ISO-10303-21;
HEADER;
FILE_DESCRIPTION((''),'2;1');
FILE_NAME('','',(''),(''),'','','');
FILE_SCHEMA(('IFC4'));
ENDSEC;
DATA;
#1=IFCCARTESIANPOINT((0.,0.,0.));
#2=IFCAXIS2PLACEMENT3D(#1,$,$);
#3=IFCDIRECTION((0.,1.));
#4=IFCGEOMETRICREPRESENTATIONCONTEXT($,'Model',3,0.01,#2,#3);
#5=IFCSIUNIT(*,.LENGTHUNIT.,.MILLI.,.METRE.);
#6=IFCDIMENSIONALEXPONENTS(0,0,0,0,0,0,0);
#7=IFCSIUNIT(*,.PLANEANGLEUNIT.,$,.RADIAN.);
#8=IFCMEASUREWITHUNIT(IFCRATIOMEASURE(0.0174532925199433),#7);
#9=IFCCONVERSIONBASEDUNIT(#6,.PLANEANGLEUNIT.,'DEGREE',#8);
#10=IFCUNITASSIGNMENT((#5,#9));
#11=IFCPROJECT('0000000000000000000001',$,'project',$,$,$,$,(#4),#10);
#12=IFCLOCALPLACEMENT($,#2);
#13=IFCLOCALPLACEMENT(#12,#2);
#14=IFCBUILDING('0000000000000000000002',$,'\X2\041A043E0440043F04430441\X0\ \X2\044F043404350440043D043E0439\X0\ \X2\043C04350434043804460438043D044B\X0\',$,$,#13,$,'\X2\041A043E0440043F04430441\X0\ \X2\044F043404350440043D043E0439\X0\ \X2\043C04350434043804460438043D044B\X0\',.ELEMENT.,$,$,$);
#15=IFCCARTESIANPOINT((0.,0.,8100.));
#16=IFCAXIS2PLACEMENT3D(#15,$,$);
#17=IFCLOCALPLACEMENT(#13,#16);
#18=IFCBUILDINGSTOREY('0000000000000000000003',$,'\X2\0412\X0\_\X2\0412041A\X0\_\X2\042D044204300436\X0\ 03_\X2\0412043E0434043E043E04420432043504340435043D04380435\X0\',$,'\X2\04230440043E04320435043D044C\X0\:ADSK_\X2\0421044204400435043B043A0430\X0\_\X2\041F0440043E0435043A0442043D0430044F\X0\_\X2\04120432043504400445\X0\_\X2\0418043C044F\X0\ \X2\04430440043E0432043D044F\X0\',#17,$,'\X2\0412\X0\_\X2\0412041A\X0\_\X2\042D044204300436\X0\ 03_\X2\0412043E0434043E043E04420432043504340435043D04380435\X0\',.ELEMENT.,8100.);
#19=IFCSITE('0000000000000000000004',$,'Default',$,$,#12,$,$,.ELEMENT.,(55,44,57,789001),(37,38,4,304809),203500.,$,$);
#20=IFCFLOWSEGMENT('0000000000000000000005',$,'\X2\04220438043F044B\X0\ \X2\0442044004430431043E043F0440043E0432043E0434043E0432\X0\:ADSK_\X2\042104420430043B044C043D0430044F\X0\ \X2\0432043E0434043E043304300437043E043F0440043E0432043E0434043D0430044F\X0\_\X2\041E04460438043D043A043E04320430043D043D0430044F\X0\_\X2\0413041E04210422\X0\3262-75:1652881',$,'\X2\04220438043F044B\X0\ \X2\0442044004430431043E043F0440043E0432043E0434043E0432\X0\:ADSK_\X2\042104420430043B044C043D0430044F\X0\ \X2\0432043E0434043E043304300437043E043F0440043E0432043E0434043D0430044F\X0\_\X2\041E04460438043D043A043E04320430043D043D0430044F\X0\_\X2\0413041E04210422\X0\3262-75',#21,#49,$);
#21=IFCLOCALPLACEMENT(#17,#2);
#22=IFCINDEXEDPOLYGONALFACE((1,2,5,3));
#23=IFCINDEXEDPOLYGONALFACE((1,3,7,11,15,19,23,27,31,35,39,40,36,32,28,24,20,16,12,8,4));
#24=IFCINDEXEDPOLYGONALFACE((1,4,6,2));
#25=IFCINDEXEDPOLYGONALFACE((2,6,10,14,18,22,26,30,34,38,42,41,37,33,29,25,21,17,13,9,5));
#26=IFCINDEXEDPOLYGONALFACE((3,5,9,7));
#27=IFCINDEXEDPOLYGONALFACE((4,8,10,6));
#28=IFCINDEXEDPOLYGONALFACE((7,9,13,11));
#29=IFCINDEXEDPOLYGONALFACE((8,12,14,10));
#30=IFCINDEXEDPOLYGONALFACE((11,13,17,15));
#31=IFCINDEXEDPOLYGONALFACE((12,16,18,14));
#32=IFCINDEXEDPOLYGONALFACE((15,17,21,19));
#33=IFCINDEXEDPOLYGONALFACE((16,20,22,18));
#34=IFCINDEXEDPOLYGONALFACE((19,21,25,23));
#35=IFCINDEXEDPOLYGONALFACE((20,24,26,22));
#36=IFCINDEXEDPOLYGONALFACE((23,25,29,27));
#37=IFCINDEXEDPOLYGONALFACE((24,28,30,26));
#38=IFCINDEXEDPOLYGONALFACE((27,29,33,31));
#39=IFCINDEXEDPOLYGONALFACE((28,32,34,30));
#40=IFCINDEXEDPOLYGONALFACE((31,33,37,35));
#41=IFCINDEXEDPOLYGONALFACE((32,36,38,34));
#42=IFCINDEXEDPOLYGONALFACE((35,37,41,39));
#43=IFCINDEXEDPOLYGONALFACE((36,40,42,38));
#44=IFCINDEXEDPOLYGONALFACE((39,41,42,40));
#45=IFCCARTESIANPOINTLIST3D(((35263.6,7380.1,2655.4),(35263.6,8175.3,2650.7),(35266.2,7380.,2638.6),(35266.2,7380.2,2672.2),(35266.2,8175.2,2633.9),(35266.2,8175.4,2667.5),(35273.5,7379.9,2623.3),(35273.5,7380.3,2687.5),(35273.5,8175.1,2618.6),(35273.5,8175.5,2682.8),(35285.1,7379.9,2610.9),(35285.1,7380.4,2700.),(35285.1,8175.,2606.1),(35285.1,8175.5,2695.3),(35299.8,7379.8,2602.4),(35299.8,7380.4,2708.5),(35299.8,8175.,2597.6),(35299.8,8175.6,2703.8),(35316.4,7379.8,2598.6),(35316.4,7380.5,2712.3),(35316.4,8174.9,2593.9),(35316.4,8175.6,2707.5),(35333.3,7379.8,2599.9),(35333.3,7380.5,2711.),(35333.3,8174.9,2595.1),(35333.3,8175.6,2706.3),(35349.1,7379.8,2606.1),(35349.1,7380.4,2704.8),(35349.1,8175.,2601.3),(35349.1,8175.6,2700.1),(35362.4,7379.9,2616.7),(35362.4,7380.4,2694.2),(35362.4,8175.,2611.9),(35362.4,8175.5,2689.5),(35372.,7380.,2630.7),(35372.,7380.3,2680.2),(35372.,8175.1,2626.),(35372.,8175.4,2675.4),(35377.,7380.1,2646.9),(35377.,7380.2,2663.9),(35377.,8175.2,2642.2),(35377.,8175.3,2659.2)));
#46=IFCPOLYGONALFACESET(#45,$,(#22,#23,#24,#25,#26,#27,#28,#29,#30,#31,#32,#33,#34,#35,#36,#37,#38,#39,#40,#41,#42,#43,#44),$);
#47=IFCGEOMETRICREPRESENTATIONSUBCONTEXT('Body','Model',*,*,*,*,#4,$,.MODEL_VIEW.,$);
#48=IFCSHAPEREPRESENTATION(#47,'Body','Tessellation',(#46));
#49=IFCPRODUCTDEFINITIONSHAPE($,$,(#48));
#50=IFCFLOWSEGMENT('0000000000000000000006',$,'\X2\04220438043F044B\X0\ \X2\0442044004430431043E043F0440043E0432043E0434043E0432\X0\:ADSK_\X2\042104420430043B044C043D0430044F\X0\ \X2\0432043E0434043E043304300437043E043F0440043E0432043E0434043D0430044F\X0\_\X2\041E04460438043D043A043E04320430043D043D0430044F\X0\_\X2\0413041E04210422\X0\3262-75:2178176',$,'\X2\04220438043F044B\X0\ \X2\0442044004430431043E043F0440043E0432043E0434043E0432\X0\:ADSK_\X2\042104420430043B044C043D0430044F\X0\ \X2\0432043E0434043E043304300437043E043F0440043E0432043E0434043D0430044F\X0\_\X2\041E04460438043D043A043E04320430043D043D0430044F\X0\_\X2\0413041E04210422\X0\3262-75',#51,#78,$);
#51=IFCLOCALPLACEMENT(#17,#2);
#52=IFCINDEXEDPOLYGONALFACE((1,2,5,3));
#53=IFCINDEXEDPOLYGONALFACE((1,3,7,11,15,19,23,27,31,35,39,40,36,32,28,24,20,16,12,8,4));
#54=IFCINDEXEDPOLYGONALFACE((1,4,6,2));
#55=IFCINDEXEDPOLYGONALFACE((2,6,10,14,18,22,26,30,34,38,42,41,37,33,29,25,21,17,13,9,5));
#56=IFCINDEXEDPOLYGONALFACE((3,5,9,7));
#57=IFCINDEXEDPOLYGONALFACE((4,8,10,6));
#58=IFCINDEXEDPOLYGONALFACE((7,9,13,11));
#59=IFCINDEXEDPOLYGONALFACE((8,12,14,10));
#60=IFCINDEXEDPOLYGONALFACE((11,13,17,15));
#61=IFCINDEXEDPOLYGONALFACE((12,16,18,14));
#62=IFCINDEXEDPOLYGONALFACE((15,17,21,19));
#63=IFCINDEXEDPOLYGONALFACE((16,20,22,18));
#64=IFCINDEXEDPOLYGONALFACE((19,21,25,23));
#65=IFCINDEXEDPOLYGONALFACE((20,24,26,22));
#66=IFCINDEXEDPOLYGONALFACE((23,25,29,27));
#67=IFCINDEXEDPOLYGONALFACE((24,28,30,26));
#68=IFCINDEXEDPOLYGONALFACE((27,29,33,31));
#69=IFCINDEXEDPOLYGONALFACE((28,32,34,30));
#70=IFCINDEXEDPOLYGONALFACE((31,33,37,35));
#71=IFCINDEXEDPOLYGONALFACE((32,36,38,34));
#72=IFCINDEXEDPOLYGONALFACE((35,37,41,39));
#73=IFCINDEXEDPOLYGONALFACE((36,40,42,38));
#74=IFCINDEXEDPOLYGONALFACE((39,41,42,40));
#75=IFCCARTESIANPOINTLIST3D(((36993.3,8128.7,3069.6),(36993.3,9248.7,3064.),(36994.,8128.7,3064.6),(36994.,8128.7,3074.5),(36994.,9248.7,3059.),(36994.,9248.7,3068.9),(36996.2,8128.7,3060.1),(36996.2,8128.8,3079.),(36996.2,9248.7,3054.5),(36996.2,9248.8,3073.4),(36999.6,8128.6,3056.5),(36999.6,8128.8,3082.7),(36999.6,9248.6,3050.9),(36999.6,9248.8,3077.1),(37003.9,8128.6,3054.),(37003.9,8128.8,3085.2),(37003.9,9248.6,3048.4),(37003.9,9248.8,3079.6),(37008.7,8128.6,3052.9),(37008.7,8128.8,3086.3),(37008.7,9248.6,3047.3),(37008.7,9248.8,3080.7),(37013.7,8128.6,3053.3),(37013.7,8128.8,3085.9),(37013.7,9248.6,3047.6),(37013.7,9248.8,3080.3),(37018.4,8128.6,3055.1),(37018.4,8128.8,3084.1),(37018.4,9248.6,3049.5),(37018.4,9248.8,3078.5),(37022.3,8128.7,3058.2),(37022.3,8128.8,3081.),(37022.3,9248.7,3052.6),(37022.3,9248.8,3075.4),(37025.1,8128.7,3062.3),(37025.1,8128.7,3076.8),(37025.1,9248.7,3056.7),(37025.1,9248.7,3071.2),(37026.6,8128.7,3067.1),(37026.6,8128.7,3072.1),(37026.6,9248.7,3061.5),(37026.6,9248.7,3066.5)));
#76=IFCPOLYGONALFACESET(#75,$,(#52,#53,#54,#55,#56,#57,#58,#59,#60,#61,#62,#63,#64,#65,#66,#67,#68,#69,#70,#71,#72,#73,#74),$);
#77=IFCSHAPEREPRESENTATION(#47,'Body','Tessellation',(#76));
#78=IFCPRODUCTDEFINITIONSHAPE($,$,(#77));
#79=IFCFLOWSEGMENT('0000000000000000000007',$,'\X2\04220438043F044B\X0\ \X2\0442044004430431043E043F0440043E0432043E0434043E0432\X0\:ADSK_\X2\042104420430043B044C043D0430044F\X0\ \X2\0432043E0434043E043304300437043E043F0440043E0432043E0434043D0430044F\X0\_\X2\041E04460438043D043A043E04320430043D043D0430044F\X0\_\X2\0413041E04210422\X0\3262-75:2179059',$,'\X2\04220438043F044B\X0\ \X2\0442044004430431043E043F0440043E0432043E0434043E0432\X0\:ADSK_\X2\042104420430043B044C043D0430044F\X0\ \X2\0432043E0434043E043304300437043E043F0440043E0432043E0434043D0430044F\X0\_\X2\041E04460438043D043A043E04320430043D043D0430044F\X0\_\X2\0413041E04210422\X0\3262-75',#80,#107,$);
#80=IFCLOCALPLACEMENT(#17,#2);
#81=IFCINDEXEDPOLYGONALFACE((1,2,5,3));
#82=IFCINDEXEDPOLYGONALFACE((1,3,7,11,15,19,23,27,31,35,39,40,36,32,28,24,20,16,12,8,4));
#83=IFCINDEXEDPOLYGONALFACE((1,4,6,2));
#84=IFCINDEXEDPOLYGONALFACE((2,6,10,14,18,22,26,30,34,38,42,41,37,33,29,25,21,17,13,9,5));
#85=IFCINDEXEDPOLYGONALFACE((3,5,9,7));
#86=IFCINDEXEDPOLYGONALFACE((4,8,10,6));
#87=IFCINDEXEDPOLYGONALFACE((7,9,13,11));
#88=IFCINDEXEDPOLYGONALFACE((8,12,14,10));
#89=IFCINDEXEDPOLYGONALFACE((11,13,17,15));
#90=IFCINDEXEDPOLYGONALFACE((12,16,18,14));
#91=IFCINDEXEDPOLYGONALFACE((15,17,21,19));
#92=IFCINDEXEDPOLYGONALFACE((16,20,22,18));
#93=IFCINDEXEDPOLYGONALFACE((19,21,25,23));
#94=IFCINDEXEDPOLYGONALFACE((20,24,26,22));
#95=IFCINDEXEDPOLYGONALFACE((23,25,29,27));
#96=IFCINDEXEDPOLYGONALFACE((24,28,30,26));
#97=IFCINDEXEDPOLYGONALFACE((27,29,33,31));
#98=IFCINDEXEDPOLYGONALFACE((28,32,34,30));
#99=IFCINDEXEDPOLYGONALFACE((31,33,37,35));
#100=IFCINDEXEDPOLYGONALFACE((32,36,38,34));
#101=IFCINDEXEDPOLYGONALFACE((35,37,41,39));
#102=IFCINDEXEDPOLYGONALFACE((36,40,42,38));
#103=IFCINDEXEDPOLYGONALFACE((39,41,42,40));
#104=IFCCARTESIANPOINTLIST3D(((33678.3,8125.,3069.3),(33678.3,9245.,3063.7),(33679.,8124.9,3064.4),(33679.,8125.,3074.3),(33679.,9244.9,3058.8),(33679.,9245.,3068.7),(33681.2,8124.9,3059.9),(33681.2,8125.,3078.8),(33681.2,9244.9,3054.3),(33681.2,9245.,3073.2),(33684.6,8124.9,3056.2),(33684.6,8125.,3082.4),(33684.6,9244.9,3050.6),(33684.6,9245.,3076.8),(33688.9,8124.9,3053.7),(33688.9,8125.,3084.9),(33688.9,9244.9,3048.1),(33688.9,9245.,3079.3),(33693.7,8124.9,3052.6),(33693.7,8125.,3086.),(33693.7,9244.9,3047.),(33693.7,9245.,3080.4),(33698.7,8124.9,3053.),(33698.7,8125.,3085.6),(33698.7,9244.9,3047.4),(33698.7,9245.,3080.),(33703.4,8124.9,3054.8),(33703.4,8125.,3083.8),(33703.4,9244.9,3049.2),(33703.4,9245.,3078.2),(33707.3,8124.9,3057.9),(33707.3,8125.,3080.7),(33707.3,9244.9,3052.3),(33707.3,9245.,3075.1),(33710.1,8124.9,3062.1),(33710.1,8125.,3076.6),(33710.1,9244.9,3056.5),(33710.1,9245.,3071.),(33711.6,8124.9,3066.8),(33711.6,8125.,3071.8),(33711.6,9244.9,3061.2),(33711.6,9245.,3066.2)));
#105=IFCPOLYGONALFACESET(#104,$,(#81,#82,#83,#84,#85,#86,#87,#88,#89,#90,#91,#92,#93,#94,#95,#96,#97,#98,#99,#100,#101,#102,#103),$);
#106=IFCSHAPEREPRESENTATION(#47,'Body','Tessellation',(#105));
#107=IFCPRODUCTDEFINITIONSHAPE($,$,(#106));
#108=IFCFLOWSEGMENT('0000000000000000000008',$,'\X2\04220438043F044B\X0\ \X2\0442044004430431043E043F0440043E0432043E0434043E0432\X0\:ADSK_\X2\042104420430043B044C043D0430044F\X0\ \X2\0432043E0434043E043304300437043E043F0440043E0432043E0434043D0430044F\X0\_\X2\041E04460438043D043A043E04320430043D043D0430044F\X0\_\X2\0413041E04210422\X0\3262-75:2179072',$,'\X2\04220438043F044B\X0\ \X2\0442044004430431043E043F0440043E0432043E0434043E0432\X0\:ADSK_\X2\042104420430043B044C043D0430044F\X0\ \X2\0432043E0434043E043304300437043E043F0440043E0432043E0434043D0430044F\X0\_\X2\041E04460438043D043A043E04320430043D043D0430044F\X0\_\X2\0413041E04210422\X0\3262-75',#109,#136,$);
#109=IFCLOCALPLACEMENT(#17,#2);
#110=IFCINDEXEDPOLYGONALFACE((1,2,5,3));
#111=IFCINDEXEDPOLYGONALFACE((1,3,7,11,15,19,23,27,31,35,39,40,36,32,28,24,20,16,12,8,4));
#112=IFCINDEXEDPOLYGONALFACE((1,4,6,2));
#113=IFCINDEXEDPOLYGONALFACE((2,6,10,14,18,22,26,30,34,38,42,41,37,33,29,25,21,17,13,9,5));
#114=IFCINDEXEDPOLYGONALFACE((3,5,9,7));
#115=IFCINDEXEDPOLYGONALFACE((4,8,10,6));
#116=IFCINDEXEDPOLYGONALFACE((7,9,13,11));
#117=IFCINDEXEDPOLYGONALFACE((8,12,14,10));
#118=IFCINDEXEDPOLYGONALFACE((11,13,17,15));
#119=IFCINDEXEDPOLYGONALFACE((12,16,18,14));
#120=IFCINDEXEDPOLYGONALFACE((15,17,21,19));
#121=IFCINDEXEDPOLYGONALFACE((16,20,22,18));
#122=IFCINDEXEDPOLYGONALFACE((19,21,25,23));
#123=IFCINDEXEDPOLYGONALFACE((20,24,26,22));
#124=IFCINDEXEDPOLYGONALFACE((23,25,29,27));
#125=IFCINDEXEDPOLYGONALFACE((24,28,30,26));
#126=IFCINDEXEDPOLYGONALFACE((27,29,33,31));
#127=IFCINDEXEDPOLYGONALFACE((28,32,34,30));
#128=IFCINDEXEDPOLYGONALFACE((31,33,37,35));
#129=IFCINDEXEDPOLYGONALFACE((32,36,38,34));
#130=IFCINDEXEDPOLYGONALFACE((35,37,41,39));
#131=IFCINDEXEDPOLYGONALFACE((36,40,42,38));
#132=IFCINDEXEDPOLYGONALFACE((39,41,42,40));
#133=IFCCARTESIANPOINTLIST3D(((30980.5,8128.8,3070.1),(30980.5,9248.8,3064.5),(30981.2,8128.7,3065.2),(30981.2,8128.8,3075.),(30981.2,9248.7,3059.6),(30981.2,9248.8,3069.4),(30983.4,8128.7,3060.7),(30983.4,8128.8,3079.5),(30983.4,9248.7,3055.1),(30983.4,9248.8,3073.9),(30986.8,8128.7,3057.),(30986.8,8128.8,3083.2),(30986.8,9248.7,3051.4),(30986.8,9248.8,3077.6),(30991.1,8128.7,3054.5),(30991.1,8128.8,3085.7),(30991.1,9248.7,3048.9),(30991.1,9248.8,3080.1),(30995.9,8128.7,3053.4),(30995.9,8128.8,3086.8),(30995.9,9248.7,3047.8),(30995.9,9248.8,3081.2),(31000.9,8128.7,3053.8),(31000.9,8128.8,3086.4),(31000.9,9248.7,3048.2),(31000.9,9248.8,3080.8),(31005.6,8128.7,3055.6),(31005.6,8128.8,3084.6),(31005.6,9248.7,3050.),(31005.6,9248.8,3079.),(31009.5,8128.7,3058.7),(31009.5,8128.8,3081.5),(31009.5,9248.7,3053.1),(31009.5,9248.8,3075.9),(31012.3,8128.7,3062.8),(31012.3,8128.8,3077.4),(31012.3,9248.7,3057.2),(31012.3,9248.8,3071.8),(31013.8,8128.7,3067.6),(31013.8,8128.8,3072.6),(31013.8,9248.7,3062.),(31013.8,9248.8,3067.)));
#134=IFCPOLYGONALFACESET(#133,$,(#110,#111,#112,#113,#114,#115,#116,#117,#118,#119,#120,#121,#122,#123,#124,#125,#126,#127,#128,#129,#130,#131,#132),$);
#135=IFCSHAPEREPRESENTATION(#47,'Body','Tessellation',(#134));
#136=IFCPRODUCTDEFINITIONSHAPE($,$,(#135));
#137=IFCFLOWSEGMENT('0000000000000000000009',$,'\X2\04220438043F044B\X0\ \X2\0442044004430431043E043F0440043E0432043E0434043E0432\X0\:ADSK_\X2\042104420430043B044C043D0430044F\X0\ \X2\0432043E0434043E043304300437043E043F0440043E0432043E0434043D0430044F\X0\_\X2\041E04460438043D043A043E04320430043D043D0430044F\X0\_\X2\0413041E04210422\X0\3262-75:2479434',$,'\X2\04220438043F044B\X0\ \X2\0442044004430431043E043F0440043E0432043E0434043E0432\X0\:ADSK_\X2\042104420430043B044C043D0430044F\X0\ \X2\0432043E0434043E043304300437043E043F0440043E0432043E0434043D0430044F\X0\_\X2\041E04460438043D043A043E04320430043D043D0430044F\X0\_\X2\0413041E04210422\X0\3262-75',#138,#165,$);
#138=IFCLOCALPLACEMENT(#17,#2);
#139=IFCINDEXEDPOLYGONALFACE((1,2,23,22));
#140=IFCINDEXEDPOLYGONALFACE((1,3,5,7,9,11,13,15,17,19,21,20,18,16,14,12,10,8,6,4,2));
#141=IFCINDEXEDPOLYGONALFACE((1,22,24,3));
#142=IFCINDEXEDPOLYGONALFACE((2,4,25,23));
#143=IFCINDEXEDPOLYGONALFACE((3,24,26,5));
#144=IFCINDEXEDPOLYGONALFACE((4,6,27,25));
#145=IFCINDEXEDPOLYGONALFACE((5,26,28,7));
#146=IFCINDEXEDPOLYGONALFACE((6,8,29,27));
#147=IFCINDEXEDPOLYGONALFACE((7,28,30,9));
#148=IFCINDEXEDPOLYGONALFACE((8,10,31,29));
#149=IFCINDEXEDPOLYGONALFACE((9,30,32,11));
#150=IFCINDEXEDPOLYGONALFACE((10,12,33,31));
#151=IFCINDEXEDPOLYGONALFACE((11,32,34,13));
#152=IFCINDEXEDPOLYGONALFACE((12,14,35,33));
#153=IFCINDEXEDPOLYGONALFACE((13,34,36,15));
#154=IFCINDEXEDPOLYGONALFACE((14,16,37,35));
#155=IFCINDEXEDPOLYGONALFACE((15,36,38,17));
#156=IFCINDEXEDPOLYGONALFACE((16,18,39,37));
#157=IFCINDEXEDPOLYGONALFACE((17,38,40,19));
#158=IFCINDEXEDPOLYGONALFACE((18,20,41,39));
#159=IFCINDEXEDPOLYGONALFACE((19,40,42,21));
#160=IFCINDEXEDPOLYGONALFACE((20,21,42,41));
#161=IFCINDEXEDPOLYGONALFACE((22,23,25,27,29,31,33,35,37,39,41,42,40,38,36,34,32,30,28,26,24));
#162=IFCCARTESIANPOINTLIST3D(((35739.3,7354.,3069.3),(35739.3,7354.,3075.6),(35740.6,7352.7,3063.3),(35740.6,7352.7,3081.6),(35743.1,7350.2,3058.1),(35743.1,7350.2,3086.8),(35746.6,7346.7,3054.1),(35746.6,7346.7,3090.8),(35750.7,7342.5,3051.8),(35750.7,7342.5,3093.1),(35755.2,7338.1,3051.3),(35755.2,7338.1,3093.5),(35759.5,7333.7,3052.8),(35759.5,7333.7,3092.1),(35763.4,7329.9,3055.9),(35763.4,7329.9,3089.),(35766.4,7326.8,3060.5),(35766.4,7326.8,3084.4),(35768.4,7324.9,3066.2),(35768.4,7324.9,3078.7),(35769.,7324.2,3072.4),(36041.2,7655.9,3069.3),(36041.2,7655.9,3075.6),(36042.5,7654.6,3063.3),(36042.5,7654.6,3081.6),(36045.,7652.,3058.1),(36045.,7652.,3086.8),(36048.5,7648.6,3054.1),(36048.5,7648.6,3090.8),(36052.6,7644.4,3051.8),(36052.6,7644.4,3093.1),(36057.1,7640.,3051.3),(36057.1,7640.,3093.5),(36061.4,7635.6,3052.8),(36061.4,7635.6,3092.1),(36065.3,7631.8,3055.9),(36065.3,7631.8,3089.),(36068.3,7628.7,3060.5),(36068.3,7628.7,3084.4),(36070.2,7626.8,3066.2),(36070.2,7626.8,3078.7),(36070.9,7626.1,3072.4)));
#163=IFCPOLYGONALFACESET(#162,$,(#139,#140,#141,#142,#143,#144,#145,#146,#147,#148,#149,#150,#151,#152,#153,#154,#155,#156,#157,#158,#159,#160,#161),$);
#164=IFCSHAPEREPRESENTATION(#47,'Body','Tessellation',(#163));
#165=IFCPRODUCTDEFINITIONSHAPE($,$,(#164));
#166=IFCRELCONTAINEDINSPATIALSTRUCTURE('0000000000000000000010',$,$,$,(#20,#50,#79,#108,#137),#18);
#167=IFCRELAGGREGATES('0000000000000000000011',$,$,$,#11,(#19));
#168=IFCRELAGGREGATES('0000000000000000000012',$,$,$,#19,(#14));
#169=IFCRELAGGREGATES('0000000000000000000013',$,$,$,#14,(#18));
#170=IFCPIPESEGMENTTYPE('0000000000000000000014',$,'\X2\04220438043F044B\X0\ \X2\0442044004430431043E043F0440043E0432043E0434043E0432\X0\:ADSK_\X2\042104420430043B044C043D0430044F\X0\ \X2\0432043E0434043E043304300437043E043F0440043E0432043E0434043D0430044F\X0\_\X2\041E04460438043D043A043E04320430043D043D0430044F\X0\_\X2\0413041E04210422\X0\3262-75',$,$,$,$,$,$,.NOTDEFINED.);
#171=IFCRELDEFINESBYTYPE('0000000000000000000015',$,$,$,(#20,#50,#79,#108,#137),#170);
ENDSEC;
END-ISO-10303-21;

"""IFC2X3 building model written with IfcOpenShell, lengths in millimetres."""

from ifc_helpers import new_model, entity, si_unit, converted_unit, direction, frame, origin, origin_2d_with_axis, place, context, subcontext, project, spatial, circle, extrude, type_object, element, save


model = new_model("IFC2X3")

# Units and contexts
model_context = context("Model", 3, precision=0.01, world=origin(), true_north=direction((0.0, 1.0)))
body_context = subcontext(model_context, "Body", "Model", "MODEL_VIEW")
ifc_project = project(units=[si_unit("LENGTHUNIT", "METRE", prefix="MILLI"), converted_unit("PLANEANGLEUNIT", "DEGREE", entity("IfcRatioMeasure", 0.0174532925199433), si_unit("PLANEANGLEUNIT", "RADIAN"), dimensions=[0, 0, 0, 0, 0, 0, 0])], contexts=[model_context])

# Site, building, storey
site_placement = place(None, origin())
site = spatial("IfcSite", under=ifc_project, at=site_placement, Name="Default", CompositionType="ELEMENT", RefLatitude=(55, 44, 57, 789001), RefLongitude=(37, 38, 4, 304809), RefElevation=203500.0)
building_placement = place(site_placement, origin())
building = spatial("IfcBuilding", under=site, at=building_placement, Name="Корпус ядерной медицины", LongName="Корпус ядерной медицины", CompositionType="ELEMENT")
storey_placement = place(building_placement, frame((0.0, 0.0, 8100.0)))
storey = spatial("IfcBuildingStorey", under=building, at=storey_placement, Name="В_ВК_Этаж 03_Водоотведение", ObjectType="Уровень:ADSK_Стрелка_Проектная_Вверх_Имя уровня", LongName="В_ВК_Этаж 03_Водоотведение", CompositionType="ELEMENT", Elevation=8100.0)

# Flow segments
pipe_segment_type_1 = type_object("IfcPipeSegmentType", Name="Типы трубопроводов:ADSK_Стальная водогазопроводная_Оцинкованная_ГОСТ3262-75", PredefinedType="NOTDEFINED")
flow_segment_1_placement = place(storey_placement, frame((35262.0, 7378.2, 2592.1)))
element("IfcFlowSegment", 1, at=flow_segment_1_placement, inside=storey, type_object=pipe_segment_type_1, Name="Типы трубопроводов:ADSK_Стальная водогазопроводная_Оцинкованная_ГОСТ3262-75:1652881", ObjectType="Типы трубопроводов:ADSK_Стальная водогазопроводная_Оцинкованная_ГОСТ3262-75", context=body_context, shape_type="SweptSolid", body=[
    extrude(circle(Radius=57.0, at=origin_2d_with_axis()), frame((58.6, 1.9, 63.3), z_axis=(-0.000003, 0.999982, -0.005956), x_axis=(-1.0, -0.000003, 0.0)), (0.0, 0.0, 1.0), 795.2),
])
for number, where, name in (
    (2, (36991.7, 8128.6, 3045.6), "Типы трубопроводов:ADSK_Стальная водогазопроводная_Оцинкованная_ГОСТ3262-75:2178176"),
    (3, (33676.7, 8124.9, 3045.4), "Типы трубопроводов:ADSK_Стальная водогазопроводная_Оцинкованная_ГОСТ3262-75:2179059"),
    (4, (30978.8, 8128.7, 3046.2), "Типы трубопроводов:ADSK_Стальная водогазопроводная_Оцинкованная_ГОСТ3262-75:2179072"),
):
    element("IfcFlowSegment", number, at=place(storey_placement, frame(where)), inside=storey, type_object=pipe_segment_type_1, Name=name, ObjectType="Типы трубопроводов:ADSK_Стальная водогазопроводная_Оцинкованная_ГОСТ3262-75", context=body_context, shape_type="SweptSolid", body=[
        extrude(circle(Radius=16.8, at=origin_2d_with_axis()), frame((18.4, 0.1, 23.9), z_axis=(0.000001, 0.999987, -0.005), x_axis=(-1.0, 0.000001, 0.0)), (0.0, 0.0, 1.0), 1120.0),
    ])
flow_segment_2_placement = place(storey_placement, frame((35737.5, 7322.6, 3049.7)))
element("IfcFlowSegment", 5, at=flow_segment_2_placement, inside=storey, type_object=pipe_segment_type_1, Name="Типы трубопроводов:ADSK_Стальная водогазопроводная_Оцинкованная_ГОСТ3262-75:2479434", ObjectType="Типы трубопроводов:ADSK_Стальная водогазопроводная_Оцинкованная_ГОСТ3262-75", context=body_context, shape_type="SweptSolid", body=[
    extrude(circle(Radius=21.1, at=origin_2d_with_axis()), frame((16.6, 16.6, 22.8), z_axis=(0.707107, 0.707107, 0.0), x_axis=(0.707107, -0.707107, 0.0)), (0.0, 0.0, 1.0), 426.9),
])

save(model, "model.ifc")
